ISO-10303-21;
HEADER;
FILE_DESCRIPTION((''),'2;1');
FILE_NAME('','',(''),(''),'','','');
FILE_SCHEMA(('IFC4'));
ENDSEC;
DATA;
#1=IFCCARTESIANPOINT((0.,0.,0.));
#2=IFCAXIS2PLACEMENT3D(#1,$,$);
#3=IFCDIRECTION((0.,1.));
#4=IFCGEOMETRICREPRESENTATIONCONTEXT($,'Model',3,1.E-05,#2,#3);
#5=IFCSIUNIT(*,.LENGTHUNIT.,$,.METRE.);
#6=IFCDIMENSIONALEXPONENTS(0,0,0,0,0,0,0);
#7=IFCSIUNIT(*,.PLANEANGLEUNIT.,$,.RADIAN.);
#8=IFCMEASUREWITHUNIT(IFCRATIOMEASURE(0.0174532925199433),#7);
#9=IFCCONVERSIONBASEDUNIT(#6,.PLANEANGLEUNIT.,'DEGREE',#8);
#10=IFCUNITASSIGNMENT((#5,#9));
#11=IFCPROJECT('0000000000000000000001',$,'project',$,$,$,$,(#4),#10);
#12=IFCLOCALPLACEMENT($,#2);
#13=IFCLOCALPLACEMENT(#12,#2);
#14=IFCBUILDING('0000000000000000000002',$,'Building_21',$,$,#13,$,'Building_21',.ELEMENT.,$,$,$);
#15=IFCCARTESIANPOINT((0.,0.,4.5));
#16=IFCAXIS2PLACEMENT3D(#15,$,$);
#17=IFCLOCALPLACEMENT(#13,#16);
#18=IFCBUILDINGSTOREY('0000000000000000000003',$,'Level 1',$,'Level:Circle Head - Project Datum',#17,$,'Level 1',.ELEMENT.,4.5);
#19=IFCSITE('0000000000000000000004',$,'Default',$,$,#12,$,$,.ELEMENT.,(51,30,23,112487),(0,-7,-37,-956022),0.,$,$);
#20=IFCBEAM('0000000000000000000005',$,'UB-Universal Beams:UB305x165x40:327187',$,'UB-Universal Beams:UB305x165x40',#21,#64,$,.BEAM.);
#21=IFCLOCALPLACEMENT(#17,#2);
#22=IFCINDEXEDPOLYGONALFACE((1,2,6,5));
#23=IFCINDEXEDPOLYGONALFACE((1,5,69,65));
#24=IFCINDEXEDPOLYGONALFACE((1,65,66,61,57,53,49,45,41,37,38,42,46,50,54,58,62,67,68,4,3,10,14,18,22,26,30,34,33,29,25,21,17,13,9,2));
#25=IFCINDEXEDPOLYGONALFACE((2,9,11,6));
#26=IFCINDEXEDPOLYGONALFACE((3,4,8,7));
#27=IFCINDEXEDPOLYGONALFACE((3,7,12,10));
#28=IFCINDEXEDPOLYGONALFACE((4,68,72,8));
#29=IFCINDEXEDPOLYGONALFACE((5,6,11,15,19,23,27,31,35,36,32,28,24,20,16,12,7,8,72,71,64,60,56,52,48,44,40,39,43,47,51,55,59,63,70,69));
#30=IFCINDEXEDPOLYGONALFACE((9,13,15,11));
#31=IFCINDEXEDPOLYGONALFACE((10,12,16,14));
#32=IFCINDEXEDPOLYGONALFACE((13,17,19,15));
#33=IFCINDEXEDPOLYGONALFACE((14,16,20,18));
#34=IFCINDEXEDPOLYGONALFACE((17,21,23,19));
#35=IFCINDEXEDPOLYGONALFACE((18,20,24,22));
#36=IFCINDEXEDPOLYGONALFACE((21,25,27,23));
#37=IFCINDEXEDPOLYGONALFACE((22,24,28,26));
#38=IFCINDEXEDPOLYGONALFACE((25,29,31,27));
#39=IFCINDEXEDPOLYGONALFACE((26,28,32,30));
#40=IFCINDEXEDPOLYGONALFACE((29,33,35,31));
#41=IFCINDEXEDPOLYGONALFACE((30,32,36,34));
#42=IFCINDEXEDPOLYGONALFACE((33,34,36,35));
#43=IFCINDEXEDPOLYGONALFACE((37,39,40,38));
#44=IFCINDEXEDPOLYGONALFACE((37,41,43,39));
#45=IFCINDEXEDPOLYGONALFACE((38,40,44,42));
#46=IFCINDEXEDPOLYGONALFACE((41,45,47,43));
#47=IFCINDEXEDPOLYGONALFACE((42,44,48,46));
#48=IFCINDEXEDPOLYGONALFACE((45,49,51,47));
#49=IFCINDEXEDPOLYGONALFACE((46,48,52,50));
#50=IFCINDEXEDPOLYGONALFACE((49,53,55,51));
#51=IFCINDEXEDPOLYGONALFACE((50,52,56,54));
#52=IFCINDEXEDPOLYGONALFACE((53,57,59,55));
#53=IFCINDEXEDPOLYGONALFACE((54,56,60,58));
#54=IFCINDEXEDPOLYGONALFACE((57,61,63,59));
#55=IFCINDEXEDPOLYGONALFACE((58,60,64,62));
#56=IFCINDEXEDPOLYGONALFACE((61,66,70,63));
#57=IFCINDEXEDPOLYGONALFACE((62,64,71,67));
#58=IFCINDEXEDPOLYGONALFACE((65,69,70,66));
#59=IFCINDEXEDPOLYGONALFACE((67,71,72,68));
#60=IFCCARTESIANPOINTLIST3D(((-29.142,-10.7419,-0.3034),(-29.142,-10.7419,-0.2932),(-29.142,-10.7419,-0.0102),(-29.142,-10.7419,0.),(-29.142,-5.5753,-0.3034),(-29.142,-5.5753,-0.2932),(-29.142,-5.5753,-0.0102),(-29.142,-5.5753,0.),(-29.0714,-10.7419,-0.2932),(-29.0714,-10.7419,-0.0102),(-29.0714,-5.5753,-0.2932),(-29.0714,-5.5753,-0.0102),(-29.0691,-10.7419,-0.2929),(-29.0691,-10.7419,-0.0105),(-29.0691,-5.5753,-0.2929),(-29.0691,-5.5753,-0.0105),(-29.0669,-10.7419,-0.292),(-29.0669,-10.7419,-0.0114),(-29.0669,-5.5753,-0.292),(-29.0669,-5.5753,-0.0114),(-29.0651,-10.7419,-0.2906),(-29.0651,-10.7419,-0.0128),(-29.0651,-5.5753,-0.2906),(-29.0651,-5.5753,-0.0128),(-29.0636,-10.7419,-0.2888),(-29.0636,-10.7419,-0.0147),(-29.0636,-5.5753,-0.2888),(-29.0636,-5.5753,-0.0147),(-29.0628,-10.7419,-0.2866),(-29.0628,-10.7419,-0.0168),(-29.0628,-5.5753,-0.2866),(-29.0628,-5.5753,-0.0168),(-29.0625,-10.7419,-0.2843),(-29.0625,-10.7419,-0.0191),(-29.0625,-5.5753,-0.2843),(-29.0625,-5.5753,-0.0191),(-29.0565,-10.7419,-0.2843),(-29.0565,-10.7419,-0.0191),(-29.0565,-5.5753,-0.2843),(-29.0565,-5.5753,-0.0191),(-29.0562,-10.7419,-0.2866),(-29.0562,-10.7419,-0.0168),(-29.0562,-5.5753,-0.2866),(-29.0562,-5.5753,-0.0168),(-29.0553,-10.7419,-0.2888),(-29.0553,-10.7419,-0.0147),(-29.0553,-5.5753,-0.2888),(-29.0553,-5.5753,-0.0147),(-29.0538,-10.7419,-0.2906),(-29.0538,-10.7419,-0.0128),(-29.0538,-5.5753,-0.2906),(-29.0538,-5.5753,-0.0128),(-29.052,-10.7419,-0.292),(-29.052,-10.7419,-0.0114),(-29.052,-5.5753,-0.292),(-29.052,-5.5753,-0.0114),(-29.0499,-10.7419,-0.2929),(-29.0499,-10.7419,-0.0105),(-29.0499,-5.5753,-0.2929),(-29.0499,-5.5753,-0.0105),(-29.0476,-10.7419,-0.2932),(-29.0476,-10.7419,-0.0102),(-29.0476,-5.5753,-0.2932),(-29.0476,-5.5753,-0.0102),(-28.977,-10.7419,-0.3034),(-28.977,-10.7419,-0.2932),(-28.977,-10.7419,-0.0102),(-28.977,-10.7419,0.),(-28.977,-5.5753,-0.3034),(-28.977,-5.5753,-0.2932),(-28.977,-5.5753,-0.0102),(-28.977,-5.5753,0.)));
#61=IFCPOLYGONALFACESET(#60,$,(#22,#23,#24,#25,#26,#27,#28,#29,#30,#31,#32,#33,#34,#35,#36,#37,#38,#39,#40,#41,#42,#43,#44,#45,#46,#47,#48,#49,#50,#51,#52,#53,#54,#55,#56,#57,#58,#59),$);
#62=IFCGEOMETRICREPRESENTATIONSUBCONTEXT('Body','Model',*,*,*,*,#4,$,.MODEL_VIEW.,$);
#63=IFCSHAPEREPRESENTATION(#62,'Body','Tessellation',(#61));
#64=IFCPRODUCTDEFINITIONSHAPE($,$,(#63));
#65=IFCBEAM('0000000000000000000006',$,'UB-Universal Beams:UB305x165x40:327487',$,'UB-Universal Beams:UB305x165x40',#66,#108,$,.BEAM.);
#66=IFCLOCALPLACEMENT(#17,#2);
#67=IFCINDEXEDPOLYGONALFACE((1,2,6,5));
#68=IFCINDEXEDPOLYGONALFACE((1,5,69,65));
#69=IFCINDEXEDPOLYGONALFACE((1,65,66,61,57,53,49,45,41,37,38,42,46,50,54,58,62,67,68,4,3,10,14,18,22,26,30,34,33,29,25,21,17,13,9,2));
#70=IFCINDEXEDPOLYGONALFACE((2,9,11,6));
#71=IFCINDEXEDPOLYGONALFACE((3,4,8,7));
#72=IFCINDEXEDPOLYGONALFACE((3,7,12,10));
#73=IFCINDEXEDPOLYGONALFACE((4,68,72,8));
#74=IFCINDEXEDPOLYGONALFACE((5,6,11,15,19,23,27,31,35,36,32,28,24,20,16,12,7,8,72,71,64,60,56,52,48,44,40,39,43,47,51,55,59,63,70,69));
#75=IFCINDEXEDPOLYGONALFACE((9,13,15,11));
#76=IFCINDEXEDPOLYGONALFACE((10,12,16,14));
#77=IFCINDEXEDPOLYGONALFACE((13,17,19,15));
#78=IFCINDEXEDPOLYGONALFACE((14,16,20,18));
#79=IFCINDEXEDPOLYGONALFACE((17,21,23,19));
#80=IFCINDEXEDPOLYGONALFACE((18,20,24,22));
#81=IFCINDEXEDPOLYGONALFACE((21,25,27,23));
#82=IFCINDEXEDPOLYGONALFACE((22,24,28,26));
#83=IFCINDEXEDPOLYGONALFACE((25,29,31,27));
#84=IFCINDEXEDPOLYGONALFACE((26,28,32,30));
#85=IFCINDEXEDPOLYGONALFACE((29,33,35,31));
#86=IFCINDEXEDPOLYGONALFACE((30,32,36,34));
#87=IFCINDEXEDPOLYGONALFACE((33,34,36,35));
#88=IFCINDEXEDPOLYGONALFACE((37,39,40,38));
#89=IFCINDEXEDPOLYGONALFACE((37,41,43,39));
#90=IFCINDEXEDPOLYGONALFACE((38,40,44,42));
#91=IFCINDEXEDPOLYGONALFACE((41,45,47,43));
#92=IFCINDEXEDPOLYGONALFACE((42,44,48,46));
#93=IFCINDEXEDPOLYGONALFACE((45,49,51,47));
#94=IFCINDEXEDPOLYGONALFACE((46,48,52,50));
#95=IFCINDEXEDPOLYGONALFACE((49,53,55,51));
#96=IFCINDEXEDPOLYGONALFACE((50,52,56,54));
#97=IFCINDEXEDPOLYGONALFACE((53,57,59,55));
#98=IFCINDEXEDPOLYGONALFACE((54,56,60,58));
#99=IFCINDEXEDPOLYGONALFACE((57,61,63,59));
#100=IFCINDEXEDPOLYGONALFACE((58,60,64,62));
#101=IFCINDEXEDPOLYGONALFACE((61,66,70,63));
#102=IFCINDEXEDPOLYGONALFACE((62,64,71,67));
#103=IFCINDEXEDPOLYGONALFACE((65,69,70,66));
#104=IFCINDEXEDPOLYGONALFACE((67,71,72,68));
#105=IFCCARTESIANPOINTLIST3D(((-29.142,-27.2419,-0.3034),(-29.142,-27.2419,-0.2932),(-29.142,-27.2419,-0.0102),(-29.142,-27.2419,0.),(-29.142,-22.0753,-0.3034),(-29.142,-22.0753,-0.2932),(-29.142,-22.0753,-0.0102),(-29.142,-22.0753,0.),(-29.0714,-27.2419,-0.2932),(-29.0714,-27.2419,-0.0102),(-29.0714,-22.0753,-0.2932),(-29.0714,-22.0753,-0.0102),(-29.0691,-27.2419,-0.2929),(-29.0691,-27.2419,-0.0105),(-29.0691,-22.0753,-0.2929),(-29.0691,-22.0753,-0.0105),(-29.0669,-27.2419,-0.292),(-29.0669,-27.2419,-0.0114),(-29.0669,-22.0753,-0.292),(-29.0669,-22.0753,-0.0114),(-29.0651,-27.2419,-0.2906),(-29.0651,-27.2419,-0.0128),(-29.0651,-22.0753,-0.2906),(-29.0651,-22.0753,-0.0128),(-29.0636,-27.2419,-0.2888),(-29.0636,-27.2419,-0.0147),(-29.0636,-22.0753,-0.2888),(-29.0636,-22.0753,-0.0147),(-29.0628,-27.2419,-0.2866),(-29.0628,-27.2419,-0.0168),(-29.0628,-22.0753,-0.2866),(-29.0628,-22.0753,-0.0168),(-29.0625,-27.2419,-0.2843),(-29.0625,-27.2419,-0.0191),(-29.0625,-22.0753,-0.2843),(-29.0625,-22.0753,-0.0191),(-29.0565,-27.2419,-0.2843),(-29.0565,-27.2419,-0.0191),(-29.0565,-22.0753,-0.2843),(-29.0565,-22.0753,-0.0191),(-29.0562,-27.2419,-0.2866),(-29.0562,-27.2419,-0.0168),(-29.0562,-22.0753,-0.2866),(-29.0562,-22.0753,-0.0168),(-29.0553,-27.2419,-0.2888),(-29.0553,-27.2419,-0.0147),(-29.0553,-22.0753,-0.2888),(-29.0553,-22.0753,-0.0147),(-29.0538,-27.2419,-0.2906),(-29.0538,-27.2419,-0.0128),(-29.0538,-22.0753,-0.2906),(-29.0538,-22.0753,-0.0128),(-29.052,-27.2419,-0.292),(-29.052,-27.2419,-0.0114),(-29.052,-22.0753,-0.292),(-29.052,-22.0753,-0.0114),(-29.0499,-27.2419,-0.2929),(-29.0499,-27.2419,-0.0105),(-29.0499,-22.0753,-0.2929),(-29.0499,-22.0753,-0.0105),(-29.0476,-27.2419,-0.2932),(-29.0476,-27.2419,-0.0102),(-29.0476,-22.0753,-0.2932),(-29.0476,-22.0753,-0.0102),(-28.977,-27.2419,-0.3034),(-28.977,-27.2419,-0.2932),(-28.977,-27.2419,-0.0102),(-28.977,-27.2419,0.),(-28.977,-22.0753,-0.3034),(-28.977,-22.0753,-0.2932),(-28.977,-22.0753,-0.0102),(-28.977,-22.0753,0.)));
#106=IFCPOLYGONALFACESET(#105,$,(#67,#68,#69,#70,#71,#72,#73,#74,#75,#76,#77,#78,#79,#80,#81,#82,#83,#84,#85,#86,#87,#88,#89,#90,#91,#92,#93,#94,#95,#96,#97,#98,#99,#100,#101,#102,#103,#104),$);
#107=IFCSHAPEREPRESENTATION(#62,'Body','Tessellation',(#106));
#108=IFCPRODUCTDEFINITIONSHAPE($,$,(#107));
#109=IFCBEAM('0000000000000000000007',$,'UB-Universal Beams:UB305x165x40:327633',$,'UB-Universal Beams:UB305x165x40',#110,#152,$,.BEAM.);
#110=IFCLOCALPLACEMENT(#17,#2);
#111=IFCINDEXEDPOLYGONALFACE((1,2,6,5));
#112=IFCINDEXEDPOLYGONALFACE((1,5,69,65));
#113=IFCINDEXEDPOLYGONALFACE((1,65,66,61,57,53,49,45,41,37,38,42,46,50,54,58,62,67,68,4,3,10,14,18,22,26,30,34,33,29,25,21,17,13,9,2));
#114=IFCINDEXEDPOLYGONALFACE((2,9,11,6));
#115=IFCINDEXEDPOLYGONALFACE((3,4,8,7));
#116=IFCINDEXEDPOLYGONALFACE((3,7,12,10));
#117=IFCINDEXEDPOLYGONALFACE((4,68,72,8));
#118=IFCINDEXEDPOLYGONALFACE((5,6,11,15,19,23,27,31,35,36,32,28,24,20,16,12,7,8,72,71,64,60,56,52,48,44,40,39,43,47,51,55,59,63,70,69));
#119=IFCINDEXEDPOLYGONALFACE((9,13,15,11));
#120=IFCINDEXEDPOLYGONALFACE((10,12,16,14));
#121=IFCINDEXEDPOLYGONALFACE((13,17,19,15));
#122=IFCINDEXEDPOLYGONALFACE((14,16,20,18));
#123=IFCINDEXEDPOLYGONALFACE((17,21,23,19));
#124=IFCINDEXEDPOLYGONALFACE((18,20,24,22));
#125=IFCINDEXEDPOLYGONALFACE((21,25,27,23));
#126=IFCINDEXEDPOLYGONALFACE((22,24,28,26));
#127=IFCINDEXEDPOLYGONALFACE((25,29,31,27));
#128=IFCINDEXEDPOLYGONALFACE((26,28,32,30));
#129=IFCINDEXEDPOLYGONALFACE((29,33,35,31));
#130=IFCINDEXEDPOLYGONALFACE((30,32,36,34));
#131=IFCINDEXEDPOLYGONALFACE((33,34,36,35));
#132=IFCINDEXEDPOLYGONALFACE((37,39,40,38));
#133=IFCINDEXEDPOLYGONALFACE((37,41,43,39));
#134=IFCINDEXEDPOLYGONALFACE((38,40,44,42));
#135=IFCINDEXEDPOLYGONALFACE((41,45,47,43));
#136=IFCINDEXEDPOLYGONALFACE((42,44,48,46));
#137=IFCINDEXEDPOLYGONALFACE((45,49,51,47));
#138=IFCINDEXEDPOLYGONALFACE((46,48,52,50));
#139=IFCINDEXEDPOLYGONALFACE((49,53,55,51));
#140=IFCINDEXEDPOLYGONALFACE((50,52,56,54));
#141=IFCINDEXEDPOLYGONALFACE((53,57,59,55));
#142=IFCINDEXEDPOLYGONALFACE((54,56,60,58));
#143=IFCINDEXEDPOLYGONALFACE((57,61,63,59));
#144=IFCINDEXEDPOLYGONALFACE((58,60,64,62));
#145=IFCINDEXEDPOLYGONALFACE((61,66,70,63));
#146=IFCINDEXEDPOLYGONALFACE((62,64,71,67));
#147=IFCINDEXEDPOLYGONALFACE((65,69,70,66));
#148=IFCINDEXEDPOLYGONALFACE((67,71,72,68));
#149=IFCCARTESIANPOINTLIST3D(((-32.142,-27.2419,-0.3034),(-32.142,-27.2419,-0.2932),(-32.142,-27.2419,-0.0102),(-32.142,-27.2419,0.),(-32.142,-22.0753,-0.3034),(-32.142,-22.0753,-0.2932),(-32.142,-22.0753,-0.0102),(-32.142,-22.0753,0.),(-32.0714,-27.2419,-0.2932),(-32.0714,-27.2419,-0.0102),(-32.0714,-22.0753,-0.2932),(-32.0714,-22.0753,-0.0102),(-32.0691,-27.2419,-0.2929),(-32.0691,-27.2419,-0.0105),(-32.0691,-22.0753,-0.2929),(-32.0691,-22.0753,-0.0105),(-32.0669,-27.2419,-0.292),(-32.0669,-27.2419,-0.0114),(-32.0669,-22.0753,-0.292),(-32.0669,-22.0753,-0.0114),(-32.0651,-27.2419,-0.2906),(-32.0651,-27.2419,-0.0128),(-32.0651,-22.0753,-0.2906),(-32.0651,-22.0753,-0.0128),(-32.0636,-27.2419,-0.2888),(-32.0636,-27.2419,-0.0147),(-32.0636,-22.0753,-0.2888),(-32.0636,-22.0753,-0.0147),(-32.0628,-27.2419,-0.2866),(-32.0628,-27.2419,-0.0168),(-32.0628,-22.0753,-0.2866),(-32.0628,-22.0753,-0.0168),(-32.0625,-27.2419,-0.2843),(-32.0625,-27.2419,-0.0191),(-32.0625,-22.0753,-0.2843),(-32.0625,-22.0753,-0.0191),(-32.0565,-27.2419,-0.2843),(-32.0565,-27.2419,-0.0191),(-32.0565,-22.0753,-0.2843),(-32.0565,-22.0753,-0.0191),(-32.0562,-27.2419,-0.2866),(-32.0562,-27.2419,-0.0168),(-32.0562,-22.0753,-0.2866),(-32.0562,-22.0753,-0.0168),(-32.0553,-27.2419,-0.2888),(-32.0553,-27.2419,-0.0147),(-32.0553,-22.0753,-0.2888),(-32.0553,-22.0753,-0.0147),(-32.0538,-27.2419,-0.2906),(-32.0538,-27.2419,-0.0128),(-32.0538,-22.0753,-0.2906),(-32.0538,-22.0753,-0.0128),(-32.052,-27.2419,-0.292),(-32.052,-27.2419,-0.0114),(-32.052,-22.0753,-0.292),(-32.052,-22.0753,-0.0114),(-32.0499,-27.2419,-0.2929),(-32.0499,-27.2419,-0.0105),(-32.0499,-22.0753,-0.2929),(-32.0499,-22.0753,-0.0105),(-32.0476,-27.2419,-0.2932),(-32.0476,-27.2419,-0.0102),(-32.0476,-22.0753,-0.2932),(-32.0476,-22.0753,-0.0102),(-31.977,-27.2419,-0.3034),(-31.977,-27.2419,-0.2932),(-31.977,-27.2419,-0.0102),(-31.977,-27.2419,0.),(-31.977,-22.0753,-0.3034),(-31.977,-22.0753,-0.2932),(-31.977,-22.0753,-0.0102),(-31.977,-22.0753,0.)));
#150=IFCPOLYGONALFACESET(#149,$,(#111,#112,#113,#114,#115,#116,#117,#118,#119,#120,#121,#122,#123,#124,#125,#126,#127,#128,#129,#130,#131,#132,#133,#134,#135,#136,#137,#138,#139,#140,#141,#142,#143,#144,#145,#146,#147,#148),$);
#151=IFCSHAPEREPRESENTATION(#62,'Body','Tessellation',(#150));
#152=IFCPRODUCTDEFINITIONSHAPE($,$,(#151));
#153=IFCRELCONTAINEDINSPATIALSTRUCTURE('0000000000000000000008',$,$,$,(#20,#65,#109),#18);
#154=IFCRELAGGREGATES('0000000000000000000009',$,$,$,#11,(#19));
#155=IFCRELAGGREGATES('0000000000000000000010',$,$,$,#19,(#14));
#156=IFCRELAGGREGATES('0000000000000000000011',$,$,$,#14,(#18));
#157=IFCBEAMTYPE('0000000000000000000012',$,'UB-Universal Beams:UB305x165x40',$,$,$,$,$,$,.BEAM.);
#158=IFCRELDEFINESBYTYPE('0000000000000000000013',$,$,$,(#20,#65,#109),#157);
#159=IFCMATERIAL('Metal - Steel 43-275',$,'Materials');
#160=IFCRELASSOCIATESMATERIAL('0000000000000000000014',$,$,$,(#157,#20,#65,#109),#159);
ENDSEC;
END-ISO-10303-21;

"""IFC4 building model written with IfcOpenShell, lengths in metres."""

from ifc_helpers import new_model, entity, si_unit, converted_unit, direction, frame, frame_2d, origin, place, context, subcontext, project, spatial, polyline, circle_curve, parameter, trimmed, segment, composite_curve, i_section, outline, extrude, source, transform, mapped, material, material_profile, profile_set, profile_usage, type_object, type_shapes, element, save


model = new_model("IFC4")

# Units and contexts
model_context = context("Model", 3, precision=1e-05, world=origin(), true_north=direction((0.0, 1.0)))
body_context = subcontext(model_context, "Body", "Model", "MODEL_VIEW")
ifc_project = project(units=[si_unit("LENGTHUNIT", "METRE"), converted_unit("PLANEANGLEUNIT", "DEGREE", entity("IfcRatioMeasure", 0.0174532925199433), si_unit("PLANEANGLEUNIT", "RADIAN"), dimensions=[0, 0, 0, 0, 0, 0, 0])], contexts=[model_context])

# Site, building, storey
site_placement = place(None, origin())
site = spatial("IfcSite", under=ifc_project, at=site_placement, Name="Default", CompositionType="ELEMENT", RefLatitude=(51, 30, 23, 112487), RefLongitude=(0, -7, -37, -956022), RefElevation=0.0)
building_placement = place(site_placement, origin())
building = spatial("IfcBuilding", under=site, at=building_placement, Name="Building_21", LongName="Building_21", CompositionType="ELEMENT")
storey_placement = place(building_placement, frame((0.0, 0.0, 4.5)))
storey = spatial("IfcBuildingStorey", under=building, at=storey_placement, Name="Level 1", ObjectType="Level:Circle Head - Project Datum", LongName="Level 1", CompositionType="ELEMENT", Elevation=4.5)

# Shared definitions
ifc_material_1 = material(Name="Metal - Steel 43-275", Category="Materials")

# Beams
ifc_material_profile_1 = material_profile(ifc_material_1, outline(composite_curve([segment(polyline([(0.0119, -0.1415, 0.0), (0.0825, -0.1415, 0.0)]), True, "CONTINUOUS"), segment(polyline([(0.0825, -0.1415, 0.0), (0.0825, -0.1517, 0.0)]), True, "CONTINUOUS"), segment(polyline([(0.0825, -0.1517, 0.0), (-0.0825, -0.1517, 0.0)]), True, "CONTINUOUS"), segment(polyline([(-0.0825, -0.1517, 0.0), (-0.0825, -0.1415, 0.0)]), True, "CONTINUOUS"), segment(polyline([(-0.0825, -0.1415, 0.0), (-0.0119, -0.1415, 0.0)]), True, "CONTINUOUS"), segment(trimmed(circle_curve(frame((-0.0119, -0.1326, 0.0), z_axis=(0.0, 0.0, 1.0), x_axis=(-1.0, 0.0, 0.0)), 0.0089), [parameter(90.0)], [parameter(180.0)], True, "PARAMETER"), True, "CONTINUOUS"), segment(polyline([(-0.003, -0.1326, 0.0), (-0.003, 0.1326, 0.0)]), True, "CONTINUOUS"), segment(trimmed(circle_curve(frame((-0.0119, 0.1326, 0.0), z_axis=(0.0, 0.0, 1.0), x_axis=(-1.0, 0.0, 0.0)), 0.0089), [parameter(180.0)], [parameter(270.0)], True, "PARAMETER"), True, "CONTINUOUS"), segment(polyline([(-0.0119, 0.1415, 0.0), (-0.0825, 0.1415, 0.0)]), True, "CONTINUOUS"), segment(polyline([(-0.0825, 0.1415, 0.0), (-0.0825, 0.1517, 0.0)]), True, "CONTINUOUS"), segment(polyline([(-0.0825, 0.1517, 0.0), (0.0825, 0.1517, 0.0)]), True, "CONTINUOUS"), segment(polyline([(0.0825, 0.1517, 0.0), (0.0825, 0.1415, 0.0)]), True, "CONTINUOUS"), segment(polyline([(0.0825, 0.1415, 0.0), (0.0119, 0.1415, 0.0)]), True, "CONTINUOUS"), segment(trimmed(circle_curve(frame((0.0119, 0.1326, 0.0), z_axis=(0.0, 0.0, 1.0), x_axis=(-1.0, 0.0, 0.0)), 0.0089), [parameter(270.0)], [parameter(0.0)], True, "PARAMETER"), True, "CONTINUOUS"), segment(polyline([(0.003, 0.1326, 0.0), (0.003, -0.1326, 0.0)]), True, "CONTINUOUS"), segment(trimmed(circle_curve(frame((0.0119, -0.1326, 0.0), z_axis=(0.0, 0.0, 1.0), x_axis=(-1.0, 0.0, 0.0)), 0.0089), [parameter(0.0)], [parameter(90.0)], True, "PARAMETER"), True, "CONTINUOUS")], self_intersect=False), kind="CURVE"), Name="UB305x165x40")
ifc_material_profile_2 = material_profile(ifc_material_1, outline(composite_curve([segment(polyline([(-1.3346, 0.0825, -0.1415), (-1.3346, 0.0825, -0.1517)]), True, "CONTINUOUS"), segment(polyline([(-1.3346, 0.0825, -0.1517), (-1.3346, -0.0825, -0.1517)]), True, "CONTINUOUS"), segment(polyline([(-1.3346, -0.0825, -0.1517), (-1.3346, -0.0825, -0.1415)]), True, "CONTINUOUS"), segment(polyline([(-1.3346, -0.0825, -0.1415), (-1.3346, -0.003, -0.1415)]), True, "CONTINUOUS"), segment(polyline([(-1.3346, -0.003, -0.1415), (-1.3346, -0.003, 0.1415)]), True, "CONTINUOUS"), segment(polyline([(-1.3346, -0.003, 0.1415), (-1.3346, -0.0825, 0.1415)]), True, "CONTINUOUS"), segment(polyline([(-1.3346, -0.0825, 0.1415), (-1.3346, -0.0825, 0.1517)]), True, "CONTINUOUS"), segment(polyline([(-1.3346, -0.0825, 0.1517), (-1.3346, 0.0825, 0.1517)]), True, "CONTINUOUS"), segment(polyline([(-1.3346, 0.0825, 0.1517), (-1.3346, 0.0825, 0.1415)]), True, "CONTINUOUS"), segment(polyline([(-1.3346, 0.0825, 0.1415), (-1.3346, 0.003, 0.1415)]), True, "CONTINUOUS"), segment(polyline([(-1.3346, 0.003, 0.1415), (-1.3346, 0.003, -0.1415)]), True, "CONTINUOUS"), segment(polyline([(-1.3346, 0.003, -0.1415), (-1.3346, 0.0825, -0.1415)]), True, "CONTINUOUS")], self_intersect=False), kind="CURVE"), Name="UB305x165x40")
ifc_profile_set_1 = profile_set([ifc_material_profile_1, ifc_material_profile_2], Name="UB305x165x40")
ifc_profile_usage_1 = profile_usage(ifc_profile_set_1, cardinal=8)
beam_type_1 = type_object("IfcBeamType", Name="UB-Universal Beams:UB305x165x40", PredefinedType="BEAM", material=ifc_profile_set_1)
shared_shape_1 = source(origin(), body_context, "Body", "SweptSolid", [
    extrude(i_section(OverallWidth=0.165, OverallDepth=0.3034, WebThickness=0.006, FlangeThickness=0.0102, FilletRadius=0.0089, at=frame_2d((0.0, 0.0), x_axis=(0.0, 1.0))), frame((-2.5833, 0.0, 0.0), z_axis=(1.0, 0.0, 0.0), x_axis=(0.0, 0.0, -1.0)), (0.0, 0.0, 1.0), 5.1666),
])
type_shapes(beam_type_1, [shared_shape_1])
beam_1_placement = place(storey_placement, frame((-29.0595, -8.1586, -0.1517), z_axis=(0.0, 0.0, 1.0), x_axis=(0.0, 1.0, 0.0)))
element("IfcBeam", 1, at=beam_1_placement, inside=storey, type_object=beam_type_1, material=ifc_profile_usage_1, Name="UB-Universal Beams:UB305x165x40:327187", ObjectType="UB-Universal Beams:UB305x165x40", PredefinedType="BEAM", context=body_context, shape_type="MappedRepresentation", body=[
    mapped(shared_shape_1, transform((0.0, 0.0, 0.0), scale=1.0)),
])
ifc_profile_usage_2 = profile_usage(ifc_profile_set_1, cardinal=8)
beam_2_placement = place(storey_placement, frame((-29.0595, -24.6586, -0.1517), z_axis=(0.0, 0.0, 1.0), x_axis=(0.0, 1.0, 0.0)))
element("IfcBeam", 2, at=beam_2_placement, inside=storey, type_object=beam_type_1, material=ifc_profile_usage_2, Name="UB-Universal Beams:UB305x165x40:327487", ObjectType="UB-Universal Beams:UB305x165x40", PredefinedType="BEAM", context=body_context, shape_type="MappedRepresentation", body=[
    mapped(shared_shape_1, transform((0.0, 0.0, 0.0), scale=1.0)),
])
ifc_profile_usage_3 = profile_usage(ifc_profile_set_1, cardinal=8)
beam_3_placement = place(storey_placement, frame((-32.0595, -24.6586, -0.1517), z_axis=(0.0, 0.0, 1.0), x_axis=(0.0, 1.0, 0.0)))
element("IfcBeam", 3, at=beam_3_placement, inside=storey, type_object=beam_type_1, material=ifc_profile_usage_3, Name="UB-Universal Beams:UB305x165x40:327633", ObjectType="UB-Universal Beams:UB305x165x40", PredefinedType="BEAM", context=body_context, shape_type="MappedRepresentation", body=[
    mapped(shared_shape_1, transform((0.0, 0.0, 0.0), scale=1.0)),
])

save(model, "model.ifc")
